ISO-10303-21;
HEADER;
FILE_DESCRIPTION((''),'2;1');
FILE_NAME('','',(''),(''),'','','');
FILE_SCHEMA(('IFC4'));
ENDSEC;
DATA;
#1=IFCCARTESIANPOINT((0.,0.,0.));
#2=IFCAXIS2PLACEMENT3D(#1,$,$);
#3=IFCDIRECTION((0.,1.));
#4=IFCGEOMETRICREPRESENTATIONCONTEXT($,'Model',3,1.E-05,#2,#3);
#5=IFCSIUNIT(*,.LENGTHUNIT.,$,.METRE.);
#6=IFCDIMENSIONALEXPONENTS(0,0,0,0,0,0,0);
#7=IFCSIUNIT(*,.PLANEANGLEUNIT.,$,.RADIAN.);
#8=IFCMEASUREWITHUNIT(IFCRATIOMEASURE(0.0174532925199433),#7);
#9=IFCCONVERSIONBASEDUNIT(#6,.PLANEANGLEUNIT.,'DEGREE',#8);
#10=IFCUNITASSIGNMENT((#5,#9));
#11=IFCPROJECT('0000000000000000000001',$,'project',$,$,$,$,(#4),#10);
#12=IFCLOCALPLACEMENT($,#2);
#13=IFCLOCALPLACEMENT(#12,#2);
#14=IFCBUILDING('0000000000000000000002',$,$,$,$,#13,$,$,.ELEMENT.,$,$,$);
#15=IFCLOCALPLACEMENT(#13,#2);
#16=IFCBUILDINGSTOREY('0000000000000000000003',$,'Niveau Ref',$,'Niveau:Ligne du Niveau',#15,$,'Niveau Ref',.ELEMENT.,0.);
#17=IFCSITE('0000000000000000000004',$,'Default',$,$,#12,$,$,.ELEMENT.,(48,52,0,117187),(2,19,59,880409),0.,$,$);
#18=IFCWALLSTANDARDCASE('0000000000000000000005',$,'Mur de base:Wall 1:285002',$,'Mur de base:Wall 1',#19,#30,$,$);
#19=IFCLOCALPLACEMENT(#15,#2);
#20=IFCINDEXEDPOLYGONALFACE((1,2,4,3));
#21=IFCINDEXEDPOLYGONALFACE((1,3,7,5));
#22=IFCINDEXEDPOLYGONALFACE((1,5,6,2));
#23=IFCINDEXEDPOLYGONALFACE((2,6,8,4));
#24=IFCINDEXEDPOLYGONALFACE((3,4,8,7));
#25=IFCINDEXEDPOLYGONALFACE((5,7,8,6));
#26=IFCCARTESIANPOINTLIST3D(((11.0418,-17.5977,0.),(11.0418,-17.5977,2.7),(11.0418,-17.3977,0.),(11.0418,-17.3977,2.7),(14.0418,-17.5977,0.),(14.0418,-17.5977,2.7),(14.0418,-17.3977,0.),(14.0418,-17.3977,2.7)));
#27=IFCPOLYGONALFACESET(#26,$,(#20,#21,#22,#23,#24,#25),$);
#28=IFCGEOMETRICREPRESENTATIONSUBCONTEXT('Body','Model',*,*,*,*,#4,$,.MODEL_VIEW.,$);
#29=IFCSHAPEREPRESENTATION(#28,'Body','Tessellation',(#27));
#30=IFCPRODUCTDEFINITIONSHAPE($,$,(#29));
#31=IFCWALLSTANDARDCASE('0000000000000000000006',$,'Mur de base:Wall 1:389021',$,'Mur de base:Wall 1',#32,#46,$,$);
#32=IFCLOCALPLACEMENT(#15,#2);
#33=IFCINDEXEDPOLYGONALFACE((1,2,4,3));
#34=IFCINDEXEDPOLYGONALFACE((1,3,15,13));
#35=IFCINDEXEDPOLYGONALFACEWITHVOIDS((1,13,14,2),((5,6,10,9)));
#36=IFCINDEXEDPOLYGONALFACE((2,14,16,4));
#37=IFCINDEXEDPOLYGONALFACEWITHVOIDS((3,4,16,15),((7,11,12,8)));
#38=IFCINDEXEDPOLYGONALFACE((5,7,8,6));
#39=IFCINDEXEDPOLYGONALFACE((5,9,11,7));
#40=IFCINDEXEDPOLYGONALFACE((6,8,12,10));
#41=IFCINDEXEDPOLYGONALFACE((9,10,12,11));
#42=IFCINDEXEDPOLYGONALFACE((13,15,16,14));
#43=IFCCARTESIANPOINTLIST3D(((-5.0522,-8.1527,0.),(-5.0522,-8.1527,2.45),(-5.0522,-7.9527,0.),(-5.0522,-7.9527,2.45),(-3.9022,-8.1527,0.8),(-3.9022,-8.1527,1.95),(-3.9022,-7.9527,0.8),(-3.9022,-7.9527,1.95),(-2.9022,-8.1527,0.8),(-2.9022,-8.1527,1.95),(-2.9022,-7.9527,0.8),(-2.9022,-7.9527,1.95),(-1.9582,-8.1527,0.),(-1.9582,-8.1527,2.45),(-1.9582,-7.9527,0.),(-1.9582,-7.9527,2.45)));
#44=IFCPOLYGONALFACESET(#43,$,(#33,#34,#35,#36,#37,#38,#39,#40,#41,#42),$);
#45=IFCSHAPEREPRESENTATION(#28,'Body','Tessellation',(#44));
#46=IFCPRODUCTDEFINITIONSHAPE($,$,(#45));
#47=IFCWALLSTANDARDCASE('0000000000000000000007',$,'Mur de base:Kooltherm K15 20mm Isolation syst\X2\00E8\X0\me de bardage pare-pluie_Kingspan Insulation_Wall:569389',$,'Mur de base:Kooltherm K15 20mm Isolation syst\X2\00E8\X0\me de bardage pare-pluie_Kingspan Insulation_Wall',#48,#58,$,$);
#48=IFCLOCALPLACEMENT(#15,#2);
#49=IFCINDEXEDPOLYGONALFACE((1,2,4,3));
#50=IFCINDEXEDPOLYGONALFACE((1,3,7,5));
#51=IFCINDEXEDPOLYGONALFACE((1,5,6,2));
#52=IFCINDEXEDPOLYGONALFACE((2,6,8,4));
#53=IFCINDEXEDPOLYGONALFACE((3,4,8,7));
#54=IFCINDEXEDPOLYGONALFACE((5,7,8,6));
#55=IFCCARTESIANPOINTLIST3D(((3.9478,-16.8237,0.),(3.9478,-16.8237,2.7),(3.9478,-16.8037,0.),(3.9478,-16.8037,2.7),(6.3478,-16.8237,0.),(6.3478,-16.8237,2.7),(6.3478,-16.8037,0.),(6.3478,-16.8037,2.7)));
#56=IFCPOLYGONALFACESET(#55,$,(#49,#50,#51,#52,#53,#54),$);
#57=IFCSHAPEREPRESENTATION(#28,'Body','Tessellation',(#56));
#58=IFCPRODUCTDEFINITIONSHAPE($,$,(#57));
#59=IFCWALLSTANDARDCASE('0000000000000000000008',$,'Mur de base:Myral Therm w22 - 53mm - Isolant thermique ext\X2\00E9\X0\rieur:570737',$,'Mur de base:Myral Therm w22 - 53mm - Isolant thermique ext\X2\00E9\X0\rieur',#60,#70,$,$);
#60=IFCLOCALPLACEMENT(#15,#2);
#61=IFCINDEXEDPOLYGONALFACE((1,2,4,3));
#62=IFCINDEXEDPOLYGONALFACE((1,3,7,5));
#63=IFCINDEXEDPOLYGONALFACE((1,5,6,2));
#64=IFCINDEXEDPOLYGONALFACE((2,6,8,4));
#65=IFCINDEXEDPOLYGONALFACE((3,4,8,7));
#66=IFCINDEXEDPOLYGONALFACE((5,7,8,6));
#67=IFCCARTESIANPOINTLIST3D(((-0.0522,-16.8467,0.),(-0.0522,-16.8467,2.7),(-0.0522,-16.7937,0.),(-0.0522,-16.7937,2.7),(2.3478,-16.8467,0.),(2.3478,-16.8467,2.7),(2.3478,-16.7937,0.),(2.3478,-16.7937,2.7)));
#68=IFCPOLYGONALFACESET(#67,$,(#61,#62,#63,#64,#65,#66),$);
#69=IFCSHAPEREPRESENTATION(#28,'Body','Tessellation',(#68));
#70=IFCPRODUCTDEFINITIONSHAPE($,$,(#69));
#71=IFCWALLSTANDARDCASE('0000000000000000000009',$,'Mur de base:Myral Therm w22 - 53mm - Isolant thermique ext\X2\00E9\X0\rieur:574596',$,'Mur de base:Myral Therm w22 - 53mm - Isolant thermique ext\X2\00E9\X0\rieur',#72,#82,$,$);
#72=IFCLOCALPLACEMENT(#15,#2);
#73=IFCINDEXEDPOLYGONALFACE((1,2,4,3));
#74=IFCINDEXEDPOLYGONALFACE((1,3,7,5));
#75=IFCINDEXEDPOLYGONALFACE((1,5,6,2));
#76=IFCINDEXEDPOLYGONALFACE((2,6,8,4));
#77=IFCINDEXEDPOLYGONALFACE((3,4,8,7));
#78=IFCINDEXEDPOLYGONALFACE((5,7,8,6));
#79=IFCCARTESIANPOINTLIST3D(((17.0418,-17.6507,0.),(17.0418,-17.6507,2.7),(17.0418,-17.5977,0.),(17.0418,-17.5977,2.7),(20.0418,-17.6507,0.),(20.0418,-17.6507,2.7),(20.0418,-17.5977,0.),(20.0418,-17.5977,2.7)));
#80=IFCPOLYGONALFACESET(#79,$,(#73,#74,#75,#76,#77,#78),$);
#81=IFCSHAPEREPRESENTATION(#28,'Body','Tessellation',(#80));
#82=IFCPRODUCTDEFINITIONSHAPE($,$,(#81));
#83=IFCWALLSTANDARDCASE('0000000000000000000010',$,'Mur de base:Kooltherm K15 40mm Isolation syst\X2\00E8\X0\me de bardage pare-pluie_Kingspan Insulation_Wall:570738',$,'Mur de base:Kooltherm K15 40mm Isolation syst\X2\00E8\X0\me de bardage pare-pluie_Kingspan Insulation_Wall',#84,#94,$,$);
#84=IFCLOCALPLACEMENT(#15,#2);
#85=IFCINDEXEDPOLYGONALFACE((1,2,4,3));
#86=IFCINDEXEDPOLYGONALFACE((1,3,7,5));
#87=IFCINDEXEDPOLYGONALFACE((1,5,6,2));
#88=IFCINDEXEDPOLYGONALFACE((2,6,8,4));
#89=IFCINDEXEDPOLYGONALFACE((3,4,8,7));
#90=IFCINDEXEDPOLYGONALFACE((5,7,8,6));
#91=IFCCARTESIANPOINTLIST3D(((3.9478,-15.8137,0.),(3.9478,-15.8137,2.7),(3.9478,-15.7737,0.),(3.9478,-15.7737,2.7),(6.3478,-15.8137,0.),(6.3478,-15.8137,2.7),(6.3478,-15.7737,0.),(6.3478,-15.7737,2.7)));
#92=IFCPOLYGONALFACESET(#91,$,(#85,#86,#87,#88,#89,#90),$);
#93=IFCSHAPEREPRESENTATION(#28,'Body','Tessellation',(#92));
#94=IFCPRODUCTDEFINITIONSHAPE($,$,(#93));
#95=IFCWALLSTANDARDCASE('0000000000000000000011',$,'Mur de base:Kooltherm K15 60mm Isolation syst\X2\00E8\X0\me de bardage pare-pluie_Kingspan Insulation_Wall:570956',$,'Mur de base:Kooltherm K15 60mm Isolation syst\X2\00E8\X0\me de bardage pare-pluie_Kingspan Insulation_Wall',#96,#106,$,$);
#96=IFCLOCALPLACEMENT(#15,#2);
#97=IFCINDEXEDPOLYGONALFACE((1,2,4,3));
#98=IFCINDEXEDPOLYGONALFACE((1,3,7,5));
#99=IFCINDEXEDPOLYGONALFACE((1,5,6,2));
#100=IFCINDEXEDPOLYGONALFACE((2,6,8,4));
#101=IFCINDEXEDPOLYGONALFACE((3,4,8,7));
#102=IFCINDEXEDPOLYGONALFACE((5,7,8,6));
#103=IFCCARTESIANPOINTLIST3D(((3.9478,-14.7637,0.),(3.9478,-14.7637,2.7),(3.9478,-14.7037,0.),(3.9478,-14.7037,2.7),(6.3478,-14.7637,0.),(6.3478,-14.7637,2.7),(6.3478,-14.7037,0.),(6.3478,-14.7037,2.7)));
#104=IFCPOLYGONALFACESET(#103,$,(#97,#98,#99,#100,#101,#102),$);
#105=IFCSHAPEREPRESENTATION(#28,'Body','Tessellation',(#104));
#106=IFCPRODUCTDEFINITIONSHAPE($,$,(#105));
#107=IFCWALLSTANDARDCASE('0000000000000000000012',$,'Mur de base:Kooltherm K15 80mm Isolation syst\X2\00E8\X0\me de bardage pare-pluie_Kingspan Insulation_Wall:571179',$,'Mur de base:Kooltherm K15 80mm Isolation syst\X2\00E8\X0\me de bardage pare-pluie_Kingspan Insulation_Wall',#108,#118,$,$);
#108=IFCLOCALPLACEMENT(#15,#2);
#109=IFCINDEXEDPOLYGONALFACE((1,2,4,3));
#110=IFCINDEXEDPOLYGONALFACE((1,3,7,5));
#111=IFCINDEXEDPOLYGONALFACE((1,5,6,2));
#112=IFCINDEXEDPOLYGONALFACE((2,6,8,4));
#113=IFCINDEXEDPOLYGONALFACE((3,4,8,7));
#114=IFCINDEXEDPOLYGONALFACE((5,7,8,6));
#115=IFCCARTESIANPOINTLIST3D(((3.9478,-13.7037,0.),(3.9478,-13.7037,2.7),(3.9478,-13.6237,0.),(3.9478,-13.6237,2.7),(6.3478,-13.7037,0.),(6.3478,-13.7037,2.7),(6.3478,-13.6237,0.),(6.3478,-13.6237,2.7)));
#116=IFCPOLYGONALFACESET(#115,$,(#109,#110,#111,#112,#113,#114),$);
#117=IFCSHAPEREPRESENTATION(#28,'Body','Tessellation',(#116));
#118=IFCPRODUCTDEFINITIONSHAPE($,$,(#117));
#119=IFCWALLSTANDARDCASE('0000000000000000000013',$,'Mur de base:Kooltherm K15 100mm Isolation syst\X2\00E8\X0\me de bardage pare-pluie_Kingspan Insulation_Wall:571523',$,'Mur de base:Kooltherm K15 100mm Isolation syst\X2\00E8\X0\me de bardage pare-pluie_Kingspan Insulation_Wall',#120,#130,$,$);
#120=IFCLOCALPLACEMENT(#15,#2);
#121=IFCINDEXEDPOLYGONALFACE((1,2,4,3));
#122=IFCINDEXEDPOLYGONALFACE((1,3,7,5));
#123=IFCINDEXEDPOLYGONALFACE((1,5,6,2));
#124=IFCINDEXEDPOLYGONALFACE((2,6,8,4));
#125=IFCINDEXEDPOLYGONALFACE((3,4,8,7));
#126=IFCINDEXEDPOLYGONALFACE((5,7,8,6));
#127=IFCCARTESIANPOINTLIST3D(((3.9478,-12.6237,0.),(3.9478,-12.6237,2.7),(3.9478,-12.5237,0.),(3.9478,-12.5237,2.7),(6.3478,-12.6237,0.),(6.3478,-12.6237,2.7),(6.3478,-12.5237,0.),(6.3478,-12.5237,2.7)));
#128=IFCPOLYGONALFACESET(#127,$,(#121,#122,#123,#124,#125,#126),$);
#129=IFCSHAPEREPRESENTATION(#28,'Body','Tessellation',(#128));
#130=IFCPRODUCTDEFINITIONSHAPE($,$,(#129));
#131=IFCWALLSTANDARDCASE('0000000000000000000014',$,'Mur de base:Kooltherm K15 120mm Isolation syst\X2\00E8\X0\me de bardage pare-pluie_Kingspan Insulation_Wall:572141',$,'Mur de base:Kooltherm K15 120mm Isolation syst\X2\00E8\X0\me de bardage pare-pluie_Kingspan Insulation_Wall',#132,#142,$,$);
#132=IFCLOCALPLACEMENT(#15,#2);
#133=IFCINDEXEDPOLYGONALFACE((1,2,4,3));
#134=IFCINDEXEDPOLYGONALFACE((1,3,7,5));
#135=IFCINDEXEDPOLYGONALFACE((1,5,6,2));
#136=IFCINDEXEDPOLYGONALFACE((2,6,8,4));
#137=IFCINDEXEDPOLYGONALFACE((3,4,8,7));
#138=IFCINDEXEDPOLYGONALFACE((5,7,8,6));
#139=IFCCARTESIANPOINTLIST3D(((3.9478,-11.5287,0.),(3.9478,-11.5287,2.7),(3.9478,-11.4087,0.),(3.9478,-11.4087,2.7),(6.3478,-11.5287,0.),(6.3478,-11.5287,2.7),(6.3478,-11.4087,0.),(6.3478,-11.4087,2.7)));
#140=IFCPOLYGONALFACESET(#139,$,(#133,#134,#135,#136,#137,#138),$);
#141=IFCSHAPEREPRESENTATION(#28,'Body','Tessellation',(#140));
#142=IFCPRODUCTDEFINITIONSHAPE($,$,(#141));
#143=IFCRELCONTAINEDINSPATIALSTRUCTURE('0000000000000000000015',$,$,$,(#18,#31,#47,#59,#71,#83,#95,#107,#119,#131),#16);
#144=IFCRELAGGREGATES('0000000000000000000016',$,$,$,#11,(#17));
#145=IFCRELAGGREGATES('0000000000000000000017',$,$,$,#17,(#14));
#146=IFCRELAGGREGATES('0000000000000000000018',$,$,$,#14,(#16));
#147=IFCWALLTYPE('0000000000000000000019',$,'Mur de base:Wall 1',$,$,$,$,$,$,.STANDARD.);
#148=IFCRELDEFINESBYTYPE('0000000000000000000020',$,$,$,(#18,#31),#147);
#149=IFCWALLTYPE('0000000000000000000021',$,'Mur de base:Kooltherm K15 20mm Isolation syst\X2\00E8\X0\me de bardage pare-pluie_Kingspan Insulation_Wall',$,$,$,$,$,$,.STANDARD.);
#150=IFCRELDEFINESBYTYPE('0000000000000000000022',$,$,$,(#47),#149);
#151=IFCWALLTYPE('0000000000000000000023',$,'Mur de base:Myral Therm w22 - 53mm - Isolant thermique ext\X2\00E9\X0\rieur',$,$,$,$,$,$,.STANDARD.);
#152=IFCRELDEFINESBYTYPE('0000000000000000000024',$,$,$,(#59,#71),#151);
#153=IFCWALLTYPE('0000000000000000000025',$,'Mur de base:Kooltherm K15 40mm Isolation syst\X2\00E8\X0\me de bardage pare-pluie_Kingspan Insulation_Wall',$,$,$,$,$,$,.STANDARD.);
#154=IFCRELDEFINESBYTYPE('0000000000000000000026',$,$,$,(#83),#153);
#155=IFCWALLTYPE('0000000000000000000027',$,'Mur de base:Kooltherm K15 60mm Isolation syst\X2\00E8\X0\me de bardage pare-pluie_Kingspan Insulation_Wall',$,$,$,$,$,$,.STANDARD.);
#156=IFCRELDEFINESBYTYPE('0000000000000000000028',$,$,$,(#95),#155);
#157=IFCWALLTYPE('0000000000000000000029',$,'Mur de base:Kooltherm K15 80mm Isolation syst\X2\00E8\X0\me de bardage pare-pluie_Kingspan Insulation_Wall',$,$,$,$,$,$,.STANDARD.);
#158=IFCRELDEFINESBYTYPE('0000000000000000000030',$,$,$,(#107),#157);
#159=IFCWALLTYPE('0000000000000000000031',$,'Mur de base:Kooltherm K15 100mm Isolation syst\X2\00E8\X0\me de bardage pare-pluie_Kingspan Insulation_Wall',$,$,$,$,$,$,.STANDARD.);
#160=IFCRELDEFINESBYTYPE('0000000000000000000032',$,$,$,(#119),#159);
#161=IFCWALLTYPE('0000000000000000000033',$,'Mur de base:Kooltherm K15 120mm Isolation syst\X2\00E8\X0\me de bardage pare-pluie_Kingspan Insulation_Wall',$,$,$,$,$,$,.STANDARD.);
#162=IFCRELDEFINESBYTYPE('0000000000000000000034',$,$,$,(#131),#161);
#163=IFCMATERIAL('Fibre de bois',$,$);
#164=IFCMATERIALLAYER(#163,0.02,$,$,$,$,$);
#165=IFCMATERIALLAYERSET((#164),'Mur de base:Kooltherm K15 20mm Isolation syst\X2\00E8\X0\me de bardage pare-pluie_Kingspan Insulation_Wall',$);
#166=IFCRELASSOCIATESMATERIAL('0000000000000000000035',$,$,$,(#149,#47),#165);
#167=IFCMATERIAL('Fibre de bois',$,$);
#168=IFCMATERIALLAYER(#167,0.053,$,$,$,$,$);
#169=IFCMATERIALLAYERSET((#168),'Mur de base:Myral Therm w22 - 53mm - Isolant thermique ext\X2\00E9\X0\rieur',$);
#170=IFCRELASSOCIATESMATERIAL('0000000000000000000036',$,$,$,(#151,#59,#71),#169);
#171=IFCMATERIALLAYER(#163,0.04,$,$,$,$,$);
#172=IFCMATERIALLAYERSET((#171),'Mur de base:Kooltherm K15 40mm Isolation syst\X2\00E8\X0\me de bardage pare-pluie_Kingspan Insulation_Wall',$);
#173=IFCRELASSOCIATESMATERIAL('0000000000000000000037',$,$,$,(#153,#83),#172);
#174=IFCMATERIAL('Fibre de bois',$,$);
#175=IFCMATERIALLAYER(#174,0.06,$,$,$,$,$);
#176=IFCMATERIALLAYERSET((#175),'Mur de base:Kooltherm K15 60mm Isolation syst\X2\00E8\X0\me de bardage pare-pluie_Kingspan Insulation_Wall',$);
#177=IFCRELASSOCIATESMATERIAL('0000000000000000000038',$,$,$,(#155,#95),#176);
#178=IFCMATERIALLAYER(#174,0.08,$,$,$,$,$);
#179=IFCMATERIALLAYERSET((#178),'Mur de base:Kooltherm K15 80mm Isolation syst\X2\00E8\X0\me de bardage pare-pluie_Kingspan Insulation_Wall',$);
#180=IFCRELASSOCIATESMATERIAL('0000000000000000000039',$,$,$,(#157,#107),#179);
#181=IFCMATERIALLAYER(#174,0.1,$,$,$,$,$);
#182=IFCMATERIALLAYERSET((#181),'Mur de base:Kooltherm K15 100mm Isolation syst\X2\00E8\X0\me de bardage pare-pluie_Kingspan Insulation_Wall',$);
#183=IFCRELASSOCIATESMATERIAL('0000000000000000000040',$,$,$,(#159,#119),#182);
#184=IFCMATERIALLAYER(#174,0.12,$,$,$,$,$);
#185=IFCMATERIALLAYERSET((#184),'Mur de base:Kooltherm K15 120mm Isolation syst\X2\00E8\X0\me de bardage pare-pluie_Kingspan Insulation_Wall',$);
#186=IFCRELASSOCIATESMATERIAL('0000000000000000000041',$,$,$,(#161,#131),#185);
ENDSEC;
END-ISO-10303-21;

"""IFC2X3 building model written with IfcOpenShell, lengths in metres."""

from ifc_helpers import new_model, entity, si_unit, converted_unit, direction, frame, frame_2d, origin, place, context, subcontext, project, spatial, rectangle, extrude, material, layer, layer_set, layer_usage, type_object, element, save


model = new_model("IFC2X3")

# Units and contexts
model_context = context("Model", 3, precision=1e-05, world=origin(), true_north=direction((0.0, 1.0)))
body_context = subcontext(model_context, "Body", "Model", "MODEL_VIEW")
ifc_project = project(units=[si_unit("LENGTHUNIT", "METRE"), converted_unit("PLANEANGLEUNIT", "DEGREE", entity("IfcRatioMeasure", 0.0174532925199433), si_unit("PLANEANGLEUNIT", "RADIAN"), dimensions=[0, 0, 0, 0, 0, 0, 0])], contexts=[model_context])

# Site, building, storey
site_placement = place(None, origin())
site = spatial("IfcSite", under=ifc_project, at=site_placement, Name="Default", CompositionType="ELEMENT", RefLatitude=(48, 52, 0, 117187), RefLongitude=(2, 19, 59, 880409), RefElevation=0.0)
building_placement = place(site_placement, origin())
building = spatial("IfcBuilding", under=site, at=building_placement, CompositionType="ELEMENT")
storey_placement = place(building_placement, origin())
storey = spatial("IfcBuildingStorey", under=building, at=storey_placement, Name="Niveau Ref", ObjectType="Niveau:Ligne du Niveau", LongName="Niveau Ref", CompositionType="ELEMENT", Elevation=0.0)

# Wall
wall_type_1 = type_object("IfcWallType", Name="Mur de base:Wall 1", PredefinedType="STANDARD")
for number, where, name in (
    (1, (11.0418, -17.4977, 0.0), "Mur de base:Wall 1:285002"),
):
    element("IfcWallStandardCase", number, at=place(storey_placement, frame(where)), inside=storey, type_object=wall_type_1, Name=name, ObjectType="Mur de base:Wall 1", context=body_context, shape_type="SweptSolid", body=[
        extrude(rectangle(XDim=3.0, YDim=0.2, at=frame_2d((1.5, 0.0), x_axis=(-1.0, 0.0))), origin(), (0.0, 0.0, 1.0), 2.7),
    ])

# Wall, opening
wall_1_placement = place(storey_placement, frame((-1.9582, -8.0527, 0.0), z_axis=(0.0, 0.0, 1.0), x_axis=(-1.0, 0.0, 0.0)))
wall_1 = element("IfcWallStandardCase", 2, at=wall_1_placement, inside=storey, type_object=wall_type_1, Name="Mur de base:Wall 1:389021", ObjectType="Mur de base:Wall 1", context=body_context, shape_type="SweptSolid", body=[
    extrude(rectangle(XDim=3.094, YDim=0.2, at=frame_2d((1.547, 0.0), x_axis=(-1.0, 0.0))), origin(), (0.0, 0.0, 1.0), 2.45),
])
opening_placement = place(wall_1_placement, frame((0.944, -0.1, 0.8)))
element("IfcOpeningElement", 3, at=opening_placement, cuts=wall_1, ObjectType="Opening", context=body_context, shape_type="SweptSolid", body=[
    extrude(rectangle(XDim=1.15, YDim=1.0, at=frame_2d((0.575, 0.5), x_axis=(1.0, 0.0))), frame((0.0, 0.0, 0.0), z_axis=(0.0, 1.0, 0.0), x_axis=(0.0, 0.0, 1.0)), (0.0, 0.0, 1.0), 0.2),
])

# Walls
ifc_material_1 = material(Name="Fibre de bois")
ifc_layer_1 = layer(ifc_material_1, 0.02)
ifc_layer_set_1 = layer_set([ifc_layer_1], Name="Mur de base:Kooltherm K15 20mm Isolation système de bardage pare-pluie_Kingspan Insulation_Wall")
ifc_layer_usage_1 = layer_usage(ifc_layer_set_1, "AXIS2", "NEGATIVE", 0.01)
wall_type_2 = type_object("IfcWallType", Name="Mur de base:Kooltherm K15 20mm Isolation système de bardage pare-pluie_Kingspan Insulation_Wall", PredefinedType="STANDARD", material=ifc_layer_set_1)
wall_2_placement = place(storey_placement, frame((3.9478, -16.8137, 0.0)))
element("IfcWallStandardCase", 4, at=wall_2_placement, inside=storey, type_object=wall_type_2, material=ifc_layer_usage_1, Name="Mur de base:Kooltherm K15 20mm Isolation système de bardage pare-pluie_Kingspan Insulation_Wall:569389", ObjectType="Mur de base:Kooltherm K15 20mm Isolation système de bardage pare-pluie_Kingspan Insulation_Wall", context=body_context, shape_type="SweptSolid", body=[
    extrude(rectangle(XDim=2.4, YDim=0.02, at=frame_2d((1.2, 0.0), x_axis=(-1.0, 0.0))), origin(), (0.0, 0.0, 1.0), 2.7),
])
ifc_material_2 = material(Name="Fibre de bois")
ifc_layer_2 = layer(ifc_material_2, 0.053)
ifc_layer_set_2 = layer_set([ifc_layer_2], Name="Mur de base:Myral Therm w22 - 53mm - Isolant thermique extérieur")
ifc_layer_usage_2 = layer_usage(ifc_layer_set_2, "AXIS2", "NEGATIVE", 0.0265)
wall_type_3 = type_object("IfcWallType", Name="Mur de base:Myral Therm w22 - 53mm - Isolant thermique extérieur", PredefinedType="STANDARD", material=ifc_layer_set_2)
wall_3_placement = place(storey_placement, frame((-0.0522, -16.8202, 0.0)))
element("IfcWallStandardCase", 5, at=wall_3_placement, inside=storey, type_object=wall_type_3, material=ifc_layer_usage_2, Name="Mur de base:Myral Therm w22 - 53mm - Isolant thermique extérieur:570737", ObjectType="Mur de base:Myral Therm w22 - 53mm - Isolant thermique extérieur", context=body_context, shape_type="SweptSolid", body=[
    extrude(rectangle(XDim=2.4, YDim=0.053, at=frame_2d((1.2, 0.0), x_axis=(-1.0, 0.0))), origin(), (0.0, 0.0, 1.0), 2.7),
])
ifc_layer_usage_3 = layer_usage(ifc_layer_set_2, "AXIS2", "NEGATIVE", 0.0265)
wall_4_placement = place(storey_placement, frame((17.0418, -17.6242, 0.0)))
element("IfcWallStandardCase", 6, at=wall_4_placement, inside=storey, type_object=wall_type_3, material=ifc_layer_usage_3, Name="Mur de base:Myral Therm w22 - 53mm - Isolant thermique extérieur:574596", ObjectType="Mur de base:Myral Therm w22 - 53mm - Isolant thermique extérieur", context=body_context, shape_type="SweptSolid", body=[
    extrude(rectangle(XDim=3.0, YDim=0.053, at=frame_2d((1.5, 0.0), x_axis=(-1.0, 0.0))), origin(), (0.0, 0.0, 1.0), 2.7),
])
ifc_layer_3 = layer(ifc_material_1, 0.04)
ifc_layer_set_3 = layer_set([ifc_layer_3], Name="Mur de base:Kooltherm K15 40mm Isolation système de bardage pare-pluie_Kingspan Insulation_Wall")
ifc_layer_usage_4 = layer_usage(ifc_layer_set_3, "AXIS2", "NEGATIVE", 0.02)
wall_type_4 = type_object("IfcWallType", Name="Mur de base:Kooltherm K15 40mm Isolation système de bardage pare-pluie_Kingspan Insulation_Wall", PredefinedType="STANDARD", material=ifc_layer_set_3)
wall_5_placement = place(storey_placement, frame((3.9478, -15.7937, 0.0)))
element("IfcWallStandardCase", 7, at=wall_5_placement, inside=storey, type_object=wall_type_4, material=ifc_layer_usage_4, Name="Mur de base:Kooltherm K15 40mm Isolation système de bardage pare-pluie_Kingspan Insulation_Wall:570738", ObjectType="Mur de base:Kooltherm K15 40mm Isolation système de bardage pare-pluie_Kingspan Insulation_Wall", context=body_context, shape_type="SweptSolid", body=[
    extrude(rectangle(XDim=2.4, YDim=0.04, at=frame_2d((1.2, 0.0), x_axis=(-1.0, 0.0))), origin(), (0.0, 0.0, 1.0), 2.7),
])
ifc_material_3 = material(Name="Fibre de bois")
ifc_layer_4 = layer(ifc_material_3, 0.06)
ifc_layer_set_4 = layer_set([ifc_layer_4], Name="Mur de base:Kooltherm K15 60mm Isolation système de bardage pare-pluie_Kingspan Insulation_Wall")
ifc_layer_usage_5 = layer_usage(ifc_layer_set_4, "AXIS2", "NEGATIVE", 0.03)
wall_type_5 = type_object("IfcWallType", Name="Mur de base:Kooltherm K15 60mm Isolation système de bardage pare-pluie_Kingspan Insulation_Wall", PredefinedType="STANDARD", material=ifc_layer_set_4)
wall_6_placement = place(storey_placement, frame((3.9478, -14.7337, 0.0)))
element("IfcWallStandardCase", 8, at=wall_6_placement, inside=storey, type_object=wall_type_5, material=ifc_layer_usage_5, Name="Mur de base:Kooltherm K15 60mm Isolation système de bardage pare-pluie_Kingspan Insulation_Wall:570956", ObjectType="Mur de base:Kooltherm K15 60mm Isolation système de bardage pare-pluie_Kingspan Insulation_Wall", context=body_context, shape_type="SweptSolid", body=[
    extrude(rectangle(XDim=2.4, YDim=0.06, at=frame_2d((1.2, 0.0), x_axis=(-1.0, 0.0))), origin(), (0.0, 0.0, 1.0), 2.7),
])
ifc_layer_5 = layer(ifc_material_3, 0.08)
ifc_layer_set_5 = layer_set([ifc_layer_5], Name="Mur de base:Kooltherm K15 80mm Isolation système de bardage pare-pluie_Kingspan Insulation_Wall")
ifc_layer_usage_6 = layer_usage(ifc_layer_set_5, "AXIS2", "NEGATIVE", 0.04)
wall_type_6 = type_object("IfcWallType", Name="Mur de base:Kooltherm K15 80mm Isolation système de bardage pare-pluie_Kingspan Insulation_Wall", PredefinedType="STANDARD", material=ifc_layer_set_5)
wall_7_placement = place(storey_placement, frame((3.9478, -13.6637, 0.0)))
element("IfcWallStandardCase", 9, at=wall_7_placement, inside=storey, type_object=wall_type_6, material=ifc_layer_usage_6, Name="Mur de base:Kooltherm K15 80mm Isolation système de bardage pare-pluie_Kingspan Insulation_Wall:571179", ObjectType="Mur de base:Kooltherm K15 80mm Isolation système de bardage pare-pluie_Kingspan Insulation_Wall", context=body_context, shape_type="SweptSolid", body=[
    extrude(rectangle(XDim=2.4, YDim=0.08, at=frame_2d((1.2, 0.0), x_axis=(-1.0, 0.0))), origin(), (0.0, 0.0, 1.0), 2.7),
])
ifc_layer_6 = layer(ifc_material_3, 0.1)
ifc_layer_set_6 = layer_set([ifc_layer_6], Name="Mur de base:Kooltherm K15 100mm Isolation système de bardage pare-pluie_Kingspan Insulation_Wall")
ifc_layer_usage_7 = layer_usage(ifc_layer_set_6, "AXIS2", "NEGATIVE", 0.05)
wall_type_7 = type_object("IfcWallType", Name="Mur de base:Kooltherm K15 100mm Isolation système de bardage pare-pluie_Kingspan Insulation_Wall", PredefinedType="STANDARD", material=ifc_layer_set_6)
wall_8_placement = place(storey_placement, frame((3.9478, -12.5737, 0.0)))
element("IfcWallStandardCase", 10, at=wall_8_placement, inside=storey, type_object=wall_type_7, material=ifc_layer_usage_7, Name="Mur de base:Kooltherm K15 100mm Isolation système de bardage pare-pluie_Kingspan Insulation_Wall:571523", ObjectType="Mur de base:Kooltherm K15 100mm Isolation système de bardage pare-pluie_Kingspan Insulation_Wall", context=body_context, shape_type="SweptSolid", body=[
    extrude(rectangle(XDim=2.4, YDim=0.1, at=frame_2d((1.2, 0.0), x_axis=(-1.0, 0.0))), origin(), (0.0, 0.0, 1.0), 2.7),
])
ifc_layer_7 = layer(ifc_material_3, 0.12)
ifc_layer_set_7 = layer_set([ifc_layer_7], Name="Mur de base:Kooltherm K15 120mm Isolation système de bardage pare-pluie_Kingspan Insulation_Wall")
ifc_layer_usage_8 = layer_usage(ifc_layer_set_7, "AXIS2", "NEGATIVE", 0.06)
wall_type_8 = type_object("IfcWallType", Name="Mur de base:Kooltherm K15 120mm Isolation système de bardage pare-pluie_Kingspan Insulation_Wall", PredefinedType="STANDARD", material=ifc_layer_set_7)
wall_9_placement = place(storey_placement, frame((3.9478, -11.4687, 0.0)))
element("IfcWallStandardCase", 11, at=wall_9_placement, inside=storey, type_object=wall_type_8, material=ifc_layer_usage_8, Name="Mur de base:Kooltherm K15 120mm Isolation système de bardage pare-pluie_Kingspan Insulation_Wall:572141", ObjectType="Mur de base:Kooltherm K15 120mm Isolation système de bardage pare-pluie_Kingspan Insulation_Wall", context=body_context, shape_type="SweptSolid", body=[
    extrude(rectangle(XDim=2.4, YDim=0.12, at=frame_2d((1.2, 0.0), x_axis=(-1.0, 0.0))), origin(), (0.0, 0.0, 1.0), 2.7),
])

save(model, "model.ifc")
